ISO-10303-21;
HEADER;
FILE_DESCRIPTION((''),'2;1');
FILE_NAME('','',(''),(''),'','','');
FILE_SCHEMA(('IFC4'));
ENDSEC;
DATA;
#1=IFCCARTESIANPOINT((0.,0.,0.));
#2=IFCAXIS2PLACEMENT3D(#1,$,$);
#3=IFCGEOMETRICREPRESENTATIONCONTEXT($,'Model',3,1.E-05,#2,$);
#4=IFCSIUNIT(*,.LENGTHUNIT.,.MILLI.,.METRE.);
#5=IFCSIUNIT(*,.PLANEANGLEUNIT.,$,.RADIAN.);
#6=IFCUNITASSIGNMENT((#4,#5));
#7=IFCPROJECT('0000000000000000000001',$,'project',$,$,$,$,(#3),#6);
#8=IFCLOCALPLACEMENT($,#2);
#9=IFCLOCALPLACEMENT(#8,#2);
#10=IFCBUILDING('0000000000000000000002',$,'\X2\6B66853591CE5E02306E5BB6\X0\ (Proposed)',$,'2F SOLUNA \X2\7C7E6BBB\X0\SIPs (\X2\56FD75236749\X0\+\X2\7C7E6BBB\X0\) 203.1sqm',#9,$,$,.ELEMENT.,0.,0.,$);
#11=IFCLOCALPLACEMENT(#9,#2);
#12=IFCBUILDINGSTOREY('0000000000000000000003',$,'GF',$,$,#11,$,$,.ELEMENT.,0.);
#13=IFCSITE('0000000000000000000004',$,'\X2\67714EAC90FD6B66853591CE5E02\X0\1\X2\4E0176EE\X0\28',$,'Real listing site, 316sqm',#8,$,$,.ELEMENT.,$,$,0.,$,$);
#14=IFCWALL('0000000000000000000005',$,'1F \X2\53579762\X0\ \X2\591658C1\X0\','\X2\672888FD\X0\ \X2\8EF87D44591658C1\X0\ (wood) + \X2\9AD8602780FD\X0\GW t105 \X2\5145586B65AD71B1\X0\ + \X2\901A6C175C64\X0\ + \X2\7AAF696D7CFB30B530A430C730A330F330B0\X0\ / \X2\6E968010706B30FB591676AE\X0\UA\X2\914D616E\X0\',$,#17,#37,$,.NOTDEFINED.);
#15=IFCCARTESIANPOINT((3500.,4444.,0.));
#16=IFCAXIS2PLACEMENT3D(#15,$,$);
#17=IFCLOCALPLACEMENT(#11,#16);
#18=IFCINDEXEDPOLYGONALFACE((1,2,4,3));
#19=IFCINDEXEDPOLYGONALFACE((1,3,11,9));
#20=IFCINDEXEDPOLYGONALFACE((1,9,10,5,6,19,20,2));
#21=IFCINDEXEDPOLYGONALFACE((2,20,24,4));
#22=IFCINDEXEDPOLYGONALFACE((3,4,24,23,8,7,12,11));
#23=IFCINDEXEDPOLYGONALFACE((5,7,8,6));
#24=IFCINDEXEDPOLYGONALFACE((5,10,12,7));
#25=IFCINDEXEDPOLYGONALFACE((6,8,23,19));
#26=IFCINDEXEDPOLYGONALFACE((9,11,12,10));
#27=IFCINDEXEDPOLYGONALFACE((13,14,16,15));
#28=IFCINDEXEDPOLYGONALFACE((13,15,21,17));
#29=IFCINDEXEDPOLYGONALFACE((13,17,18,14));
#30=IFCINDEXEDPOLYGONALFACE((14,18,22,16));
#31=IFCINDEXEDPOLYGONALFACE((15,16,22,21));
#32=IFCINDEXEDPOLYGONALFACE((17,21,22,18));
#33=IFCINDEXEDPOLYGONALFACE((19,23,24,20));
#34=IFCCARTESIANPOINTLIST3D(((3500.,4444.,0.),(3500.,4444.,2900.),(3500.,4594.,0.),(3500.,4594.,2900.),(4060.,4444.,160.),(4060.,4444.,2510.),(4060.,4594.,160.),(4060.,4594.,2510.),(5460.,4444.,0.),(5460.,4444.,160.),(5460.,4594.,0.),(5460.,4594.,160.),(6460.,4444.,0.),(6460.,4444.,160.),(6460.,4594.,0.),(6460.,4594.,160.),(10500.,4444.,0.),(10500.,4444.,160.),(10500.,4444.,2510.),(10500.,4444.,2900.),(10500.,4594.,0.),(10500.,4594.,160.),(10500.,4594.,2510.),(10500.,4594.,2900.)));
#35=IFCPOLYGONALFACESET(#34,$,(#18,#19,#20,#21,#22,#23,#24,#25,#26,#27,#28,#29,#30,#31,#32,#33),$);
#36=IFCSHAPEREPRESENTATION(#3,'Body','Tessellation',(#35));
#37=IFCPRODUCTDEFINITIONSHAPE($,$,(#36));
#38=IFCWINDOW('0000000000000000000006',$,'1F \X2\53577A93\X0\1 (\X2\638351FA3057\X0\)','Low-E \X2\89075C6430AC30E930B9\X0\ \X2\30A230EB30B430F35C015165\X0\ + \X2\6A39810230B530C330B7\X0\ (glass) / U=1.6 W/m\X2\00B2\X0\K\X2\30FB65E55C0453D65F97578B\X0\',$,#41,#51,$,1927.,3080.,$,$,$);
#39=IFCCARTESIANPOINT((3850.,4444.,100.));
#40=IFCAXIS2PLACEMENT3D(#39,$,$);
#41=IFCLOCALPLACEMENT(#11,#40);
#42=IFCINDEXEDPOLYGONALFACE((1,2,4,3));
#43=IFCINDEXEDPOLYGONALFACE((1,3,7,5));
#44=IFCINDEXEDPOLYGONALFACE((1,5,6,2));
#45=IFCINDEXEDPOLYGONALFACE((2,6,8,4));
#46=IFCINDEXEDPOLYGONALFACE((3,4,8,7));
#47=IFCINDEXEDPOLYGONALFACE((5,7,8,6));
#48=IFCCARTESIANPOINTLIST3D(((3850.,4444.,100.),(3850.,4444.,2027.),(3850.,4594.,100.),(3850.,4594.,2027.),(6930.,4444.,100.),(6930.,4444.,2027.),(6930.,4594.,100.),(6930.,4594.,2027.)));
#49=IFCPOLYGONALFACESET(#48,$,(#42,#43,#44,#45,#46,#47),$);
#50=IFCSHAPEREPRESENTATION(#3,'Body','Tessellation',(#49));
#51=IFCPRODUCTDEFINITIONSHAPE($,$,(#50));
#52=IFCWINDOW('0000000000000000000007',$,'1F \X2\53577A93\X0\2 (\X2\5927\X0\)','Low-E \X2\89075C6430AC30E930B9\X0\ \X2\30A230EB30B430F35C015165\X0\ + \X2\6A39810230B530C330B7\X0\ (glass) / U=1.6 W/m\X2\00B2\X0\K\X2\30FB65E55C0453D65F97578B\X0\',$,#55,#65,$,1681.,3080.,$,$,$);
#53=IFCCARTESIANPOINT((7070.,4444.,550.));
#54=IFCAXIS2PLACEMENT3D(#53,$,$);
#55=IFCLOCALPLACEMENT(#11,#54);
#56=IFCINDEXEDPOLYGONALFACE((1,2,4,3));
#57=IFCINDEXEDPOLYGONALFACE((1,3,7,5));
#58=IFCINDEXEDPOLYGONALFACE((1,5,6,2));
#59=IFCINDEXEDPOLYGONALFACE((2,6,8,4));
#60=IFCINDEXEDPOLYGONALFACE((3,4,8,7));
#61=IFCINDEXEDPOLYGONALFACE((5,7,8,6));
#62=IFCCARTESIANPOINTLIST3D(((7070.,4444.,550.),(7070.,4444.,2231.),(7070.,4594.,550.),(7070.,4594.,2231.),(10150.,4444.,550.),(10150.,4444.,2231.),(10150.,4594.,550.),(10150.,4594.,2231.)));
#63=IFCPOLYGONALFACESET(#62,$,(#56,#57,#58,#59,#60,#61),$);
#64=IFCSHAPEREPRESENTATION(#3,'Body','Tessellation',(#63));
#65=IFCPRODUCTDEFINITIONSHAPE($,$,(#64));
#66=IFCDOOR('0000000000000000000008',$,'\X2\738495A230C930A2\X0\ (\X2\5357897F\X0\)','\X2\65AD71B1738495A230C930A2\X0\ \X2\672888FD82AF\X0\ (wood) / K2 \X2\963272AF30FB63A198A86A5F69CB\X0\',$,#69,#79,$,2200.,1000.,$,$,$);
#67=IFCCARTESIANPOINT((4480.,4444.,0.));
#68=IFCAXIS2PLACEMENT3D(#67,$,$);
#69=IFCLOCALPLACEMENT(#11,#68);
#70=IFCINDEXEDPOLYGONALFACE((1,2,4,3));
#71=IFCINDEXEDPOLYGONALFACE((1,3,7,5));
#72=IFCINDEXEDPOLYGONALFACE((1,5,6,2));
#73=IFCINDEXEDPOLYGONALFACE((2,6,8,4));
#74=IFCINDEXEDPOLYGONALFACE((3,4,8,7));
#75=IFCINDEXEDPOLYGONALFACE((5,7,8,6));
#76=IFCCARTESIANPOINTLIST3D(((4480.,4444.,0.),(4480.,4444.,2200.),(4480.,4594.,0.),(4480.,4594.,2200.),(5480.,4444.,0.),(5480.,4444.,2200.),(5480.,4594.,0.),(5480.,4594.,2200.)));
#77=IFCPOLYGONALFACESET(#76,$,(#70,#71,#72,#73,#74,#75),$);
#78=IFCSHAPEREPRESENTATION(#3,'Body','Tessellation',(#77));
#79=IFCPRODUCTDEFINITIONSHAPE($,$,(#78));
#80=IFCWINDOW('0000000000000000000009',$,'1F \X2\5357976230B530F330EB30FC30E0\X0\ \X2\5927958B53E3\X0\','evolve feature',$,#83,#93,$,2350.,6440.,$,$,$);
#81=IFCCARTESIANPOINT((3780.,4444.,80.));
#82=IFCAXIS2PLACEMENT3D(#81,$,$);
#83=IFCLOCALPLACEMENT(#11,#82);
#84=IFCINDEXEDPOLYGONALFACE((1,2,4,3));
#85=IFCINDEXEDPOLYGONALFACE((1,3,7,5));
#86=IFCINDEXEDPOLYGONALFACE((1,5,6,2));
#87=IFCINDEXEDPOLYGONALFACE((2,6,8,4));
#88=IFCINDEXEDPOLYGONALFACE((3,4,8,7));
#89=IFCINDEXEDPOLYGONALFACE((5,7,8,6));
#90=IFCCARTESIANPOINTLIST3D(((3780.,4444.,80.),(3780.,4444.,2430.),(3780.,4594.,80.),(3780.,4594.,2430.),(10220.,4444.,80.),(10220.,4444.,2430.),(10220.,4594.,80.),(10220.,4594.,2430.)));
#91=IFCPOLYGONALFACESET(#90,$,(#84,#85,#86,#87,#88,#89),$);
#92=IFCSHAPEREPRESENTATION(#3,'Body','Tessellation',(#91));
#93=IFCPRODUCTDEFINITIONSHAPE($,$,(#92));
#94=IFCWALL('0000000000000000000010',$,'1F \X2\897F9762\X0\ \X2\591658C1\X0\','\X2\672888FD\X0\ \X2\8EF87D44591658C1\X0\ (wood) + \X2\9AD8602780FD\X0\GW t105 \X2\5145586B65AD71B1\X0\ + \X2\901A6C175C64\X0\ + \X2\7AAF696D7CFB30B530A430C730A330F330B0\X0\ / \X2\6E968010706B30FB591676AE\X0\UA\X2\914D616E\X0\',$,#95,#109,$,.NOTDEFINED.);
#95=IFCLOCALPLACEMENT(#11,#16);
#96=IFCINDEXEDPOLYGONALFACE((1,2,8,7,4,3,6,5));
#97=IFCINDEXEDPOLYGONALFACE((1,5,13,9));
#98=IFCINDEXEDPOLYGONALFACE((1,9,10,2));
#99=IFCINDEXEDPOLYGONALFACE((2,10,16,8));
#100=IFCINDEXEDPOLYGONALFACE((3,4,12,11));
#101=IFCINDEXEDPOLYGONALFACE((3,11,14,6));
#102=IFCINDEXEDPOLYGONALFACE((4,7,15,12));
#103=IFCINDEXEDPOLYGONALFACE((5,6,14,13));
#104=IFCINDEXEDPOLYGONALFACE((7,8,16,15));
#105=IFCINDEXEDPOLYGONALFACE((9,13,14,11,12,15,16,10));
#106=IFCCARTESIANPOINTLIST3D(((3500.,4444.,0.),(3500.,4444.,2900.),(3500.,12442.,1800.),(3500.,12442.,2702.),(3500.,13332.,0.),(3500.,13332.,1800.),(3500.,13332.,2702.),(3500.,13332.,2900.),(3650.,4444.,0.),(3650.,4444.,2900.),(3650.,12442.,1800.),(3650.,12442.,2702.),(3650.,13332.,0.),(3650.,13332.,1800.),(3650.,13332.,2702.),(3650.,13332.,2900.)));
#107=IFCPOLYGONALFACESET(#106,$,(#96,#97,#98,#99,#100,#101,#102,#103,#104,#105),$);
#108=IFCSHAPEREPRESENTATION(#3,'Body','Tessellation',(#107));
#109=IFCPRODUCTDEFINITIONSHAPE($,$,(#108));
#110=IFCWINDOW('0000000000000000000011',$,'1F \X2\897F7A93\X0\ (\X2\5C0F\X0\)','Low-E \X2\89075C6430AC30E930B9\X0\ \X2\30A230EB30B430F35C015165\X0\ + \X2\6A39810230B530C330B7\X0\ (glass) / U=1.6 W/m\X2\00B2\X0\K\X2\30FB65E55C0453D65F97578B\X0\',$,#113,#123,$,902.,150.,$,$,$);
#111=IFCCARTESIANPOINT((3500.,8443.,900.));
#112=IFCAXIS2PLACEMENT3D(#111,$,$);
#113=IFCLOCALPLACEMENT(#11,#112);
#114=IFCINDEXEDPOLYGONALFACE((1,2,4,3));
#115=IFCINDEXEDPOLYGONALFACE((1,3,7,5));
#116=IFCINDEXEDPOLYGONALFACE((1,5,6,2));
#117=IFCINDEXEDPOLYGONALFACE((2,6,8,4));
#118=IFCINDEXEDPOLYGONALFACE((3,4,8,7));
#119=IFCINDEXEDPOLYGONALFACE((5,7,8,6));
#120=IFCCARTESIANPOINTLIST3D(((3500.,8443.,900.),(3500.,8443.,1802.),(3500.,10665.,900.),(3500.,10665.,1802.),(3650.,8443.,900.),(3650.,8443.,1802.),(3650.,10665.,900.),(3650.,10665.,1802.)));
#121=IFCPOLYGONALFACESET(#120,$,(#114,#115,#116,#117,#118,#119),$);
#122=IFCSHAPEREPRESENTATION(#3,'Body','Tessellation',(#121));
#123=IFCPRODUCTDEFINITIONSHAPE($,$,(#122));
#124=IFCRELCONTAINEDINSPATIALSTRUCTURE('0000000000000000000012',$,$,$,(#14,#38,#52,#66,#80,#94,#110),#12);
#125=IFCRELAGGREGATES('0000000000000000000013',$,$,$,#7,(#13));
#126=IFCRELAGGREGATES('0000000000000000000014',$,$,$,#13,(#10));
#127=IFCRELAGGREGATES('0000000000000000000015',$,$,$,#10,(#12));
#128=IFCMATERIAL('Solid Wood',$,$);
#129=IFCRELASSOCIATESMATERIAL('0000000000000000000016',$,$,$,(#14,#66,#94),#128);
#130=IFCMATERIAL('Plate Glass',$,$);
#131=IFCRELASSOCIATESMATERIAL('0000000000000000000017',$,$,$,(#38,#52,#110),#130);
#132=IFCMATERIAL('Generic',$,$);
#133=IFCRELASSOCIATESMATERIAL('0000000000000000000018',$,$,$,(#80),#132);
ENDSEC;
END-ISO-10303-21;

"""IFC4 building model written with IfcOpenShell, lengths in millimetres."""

from ifc_helpers import new_model, si_unit, frame, frame_2d, origin, place, context, project, spatial, rectangle, extrude, material, element, fill, save


model = new_model("IFC4")

# Units and contexts
model_context = context("Model", 3, precision=1e-05, world=origin())
ifc_project = project(units=[si_unit("LENGTHUNIT", "METRE", prefix="MILLI"), si_unit("PLANEANGLEUNIT", "RADIAN")], contexts=[model_context])

# Site, building, storey
site_placement = place(None, origin())
site = spatial("IfcSite", under=ifc_project, at=site_placement, Name="東京都武蔵野市1丁目28", ObjectType="Real listing site, 316sqm", CompositionType="ELEMENT", RefElevation=0.0)
building_placement = place(site_placement, origin())
building = spatial("IfcBuilding", under=site, at=building_placement, Name="武蔵野市の家 (Proposed)", ObjectType="2F SOLUNA 籾殻SIPs (国産杉+籾殻) 203.1sqm", CompositionType="ELEMENT", ElevationOfRefHeight=0.0, ElevationOfTerrain=0.0)
storey_placement = place(building_placement, origin())
storey = spatial("IfcBuildingStorey", under=building, at=storey_placement, Name="GF", CompositionType="ELEMENT", Elevation=0.0)

# Shared definitions
ifc_material_1 = material(Name="Solid Wood")

# Wall, openings, windows, door
wall_1_placement = place(storey_placement, frame((3500.0, 4444.0, 0.0)))
wall_1 = element("IfcWall", 1, at=wall_1_placement, inside=storey, material=ifc_material_1, Name="1F 南面 外壁", Description="木製 軸組外壁 (wood) + 高性能GW t105 充填断熱 + 通気層 + 窯業系サイディング / 準耐火・外皮UA配慮", PredefinedType="NOTDEFINED", context=model_context, shape_type="SweptSolid", body=[
    extrude(rectangle(XDim=7000.0, YDim=150.0, at=frame_2d((3500.0, 75.0))), frame((3500.0, 4444.0, 0.0)), (0.0, 0.0, 1.0), 2900.0),
])
opening_1_placement = place(storey_placement, frame((3850.0, 4444.0, 100.0)))
opening_1 = element("IfcOpeningElement", 2, at=opening_1_placement, cuts=wall_1, PredefinedType="NOTDEFINED", context=model_context, shape_type="SweptSolid", body=[
    extrude(rectangle(XDim=3080.0, YDim=150.0, at=frame_2d((1540.0, 75.0))), frame((3850.0, 4444.0, 100.0)), (0.0, 0.0, 1.0), 1927.0),
])
opening_2_placement = place(storey_placement, frame((7070.0, 4444.0, 550.0)))
opening_2 = element("IfcOpeningElement", 3, at=opening_2_placement, cuts=wall_1, PredefinedType="NOTDEFINED", context=model_context, shape_type="SweptSolid", body=[
    extrude(rectangle(XDim=3080.0, YDim=150.0, at=frame_2d((1540.0, 75.0))), frame((7070.0, 4444.0, 550.0)), (0.0, 0.0, 1.0), 1681.0),
])
opening_3_placement = place(storey_placement, frame((4480.0, 4444.0, 0.0)))
opening_3 = element("IfcOpeningElement", 4, at=opening_3_placement, cuts=wall_1, PredefinedType="NOTDEFINED", context=model_context, shape_type="SweptSolid", body=[
    extrude(rectangle(XDim=1000.0, YDim=150.0, at=frame_2d((500.0, 75.0))), frame((4480.0, 4444.0, 0.0)), (0.0, 0.0, 1.0), 2200.0),
])
opening_4_placement = place(storey_placement, frame((3780.0, 4444.0, 80.0)))
opening_4 = element("IfcOpeningElement", 5, at=opening_4_placement, cuts=wall_1, PredefinedType="NOTDEFINED", context=model_context, shape_type="SweptSolid", body=[
    extrude(rectangle(XDim=6440.0, YDim=150.0, at=frame_2d((3220.0, 75.0))), frame((3780.0, 4444.0, 80.0)), (0.0, 0.0, 1.0), 2350.0),
])
ifc_material_2 = material(Name="Plate Glass")
window_1_placement = place(storey_placement, frame((3850.0, 4444.0, 100.0)))
window_1 = element("IfcWindow", 6, at=window_1_placement, inside=storey, material=ifc_material_2, Name="1F 南窓1 (掃出し)", Description="Low-E 複層ガラス アルゴン封入 + 樹脂サッシ (glass) / U=1.6 W/m²K・日射取得型", OverallHeight=1927.0, OverallWidth=3080.0, context=model_context, shape_type="SweptSolid", body=[
    extrude(rectangle(XDim=3080.0, YDim=150.0, at=frame_2d((1540.0, 75.0))), frame((3850.0, 4444.0, 100.0)), (0.0, 0.0, 1.0), 1927.0),
])
fill(opening_1, window_1)
window_2_placement = place(storey_placement, frame((7070.0, 4444.0, 550.0)))
window_2 = element("IfcWindow", 7, at=window_2_placement, inside=storey, material=ifc_material_2, Name="1F 南窓2 (大)", Description="Low-E 複層ガラス アルゴン封入 + 樹脂サッシ (glass) / U=1.6 W/m²K・日射取得型", OverallHeight=1681.0, OverallWidth=3080.0, context=model_context, shape_type="SweptSolid", body=[
    extrude(rectangle(XDim=3080.0, YDim=150.0, at=frame_2d((1540.0, 75.0))), frame((7070.0, 4444.0, 550.0)), (0.0, 0.0, 1.0), 1681.0),
])
fill(opening_2, window_2)
door_placement = place(storey_placement, frame((4480.0, 4444.0, 0.0)))
door = element("IfcDoor", 8, at=door_placement, inside=storey, material=ifc_material_1, Name="玄関ドア (南西)", Description="断熱玄関ドア 木製芯 (wood) / K2 防犯・採風機構", OverallHeight=2200.0, OverallWidth=1000.0, context=model_context, shape_type="SweptSolid", body=[
    extrude(rectangle(XDim=1000.0, YDim=150.0, at=frame_2d((500.0, 75.0))), frame((4480.0, 4444.0, 0.0)), (0.0, 0.0, 1.0), 2200.0),
])
fill(opening_3, door)
ifc_material_3 = material(Name="Generic")
window_3_placement = place(storey_placement, frame((3780.0, 4444.0, 80.0)))
window_3 = element("IfcWindow", 9, at=window_3_placement, inside=storey, material=ifc_material_3, Name="1F 南面サンルーム 大開口", Description="evolve feature", OverallHeight=2350.0, OverallWidth=6440.0, context=model_context, shape_type="SweptSolid", body=[
    extrude(rectangle(XDim=6440.0, YDim=150.0, at=frame_2d((3220.0, 75.0))), frame((3780.0, 4444.0, 80.0)), (0.0, 0.0, 1.0), 2350.0),
])
fill(opening_4, window_3)

# Wall, opening, window
wall_2_placement = place(storey_placement, frame((3500.0, 4444.0, 0.0)))
wall_2 = element("IfcWall", 10, at=wall_2_placement, inside=storey, material=ifc_material_1, Name="1F 西面 外壁", Description="木製 軸組外壁 (wood) + 高性能GW t105 充填断熱 + 通気層 + 窯業系サイディング / 準耐火・外皮UA配慮", PredefinedType="NOTDEFINED", context=model_context, shape_type="SweptSolid", body=[
    extrude(rectangle(XDim=150.0, YDim=8888.0, at=frame_2d((75.0, 4444.0))), frame((3500.0, 4444.0, 0.0)), (0.0, 0.0, 1.0), 2900.0),
])
opening_5_placement = place(storey_placement, frame((3500.0, 8443.0, 900.0)))
opening_5 = element("IfcOpeningElement", 11, at=opening_5_placement, cuts=wall_2, PredefinedType="NOTDEFINED", context=model_context, shape_type="SweptSolid", body=[
    extrude(rectangle(XDim=150.0, YDim=2222.0, at=frame_2d((75.0, 1111.0))), frame((3500.0, 8443.0, 900.0)), (0.0, 0.0, 1.0), 902.0),
])
window_4_placement = place(storey_placement, frame((3500.0, 8443.0, 900.0)))
window_4 = element("IfcWindow", 12, at=window_4_placement, inside=storey, material=ifc_material_2, Name="1F 西窓 (小)", Description="Low-E 複層ガラス アルゴン封入 + 樹脂サッシ (glass) / U=1.6 W/m²K・日射取得型", OverallHeight=902.0, OverallWidth=150.0, context=model_context, shape_type="SweptSolid", body=[
    extrude(rectangle(XDim=150.0, YDim=2222.0, at=frame_2d((75.0, 1111.0))), frame((3500.0, 8443.0, 900.0)), (0.0, 0.0, 1.0), 902.0),
])
fill(opening_5, window_4)

save(model, "model.ifc")
